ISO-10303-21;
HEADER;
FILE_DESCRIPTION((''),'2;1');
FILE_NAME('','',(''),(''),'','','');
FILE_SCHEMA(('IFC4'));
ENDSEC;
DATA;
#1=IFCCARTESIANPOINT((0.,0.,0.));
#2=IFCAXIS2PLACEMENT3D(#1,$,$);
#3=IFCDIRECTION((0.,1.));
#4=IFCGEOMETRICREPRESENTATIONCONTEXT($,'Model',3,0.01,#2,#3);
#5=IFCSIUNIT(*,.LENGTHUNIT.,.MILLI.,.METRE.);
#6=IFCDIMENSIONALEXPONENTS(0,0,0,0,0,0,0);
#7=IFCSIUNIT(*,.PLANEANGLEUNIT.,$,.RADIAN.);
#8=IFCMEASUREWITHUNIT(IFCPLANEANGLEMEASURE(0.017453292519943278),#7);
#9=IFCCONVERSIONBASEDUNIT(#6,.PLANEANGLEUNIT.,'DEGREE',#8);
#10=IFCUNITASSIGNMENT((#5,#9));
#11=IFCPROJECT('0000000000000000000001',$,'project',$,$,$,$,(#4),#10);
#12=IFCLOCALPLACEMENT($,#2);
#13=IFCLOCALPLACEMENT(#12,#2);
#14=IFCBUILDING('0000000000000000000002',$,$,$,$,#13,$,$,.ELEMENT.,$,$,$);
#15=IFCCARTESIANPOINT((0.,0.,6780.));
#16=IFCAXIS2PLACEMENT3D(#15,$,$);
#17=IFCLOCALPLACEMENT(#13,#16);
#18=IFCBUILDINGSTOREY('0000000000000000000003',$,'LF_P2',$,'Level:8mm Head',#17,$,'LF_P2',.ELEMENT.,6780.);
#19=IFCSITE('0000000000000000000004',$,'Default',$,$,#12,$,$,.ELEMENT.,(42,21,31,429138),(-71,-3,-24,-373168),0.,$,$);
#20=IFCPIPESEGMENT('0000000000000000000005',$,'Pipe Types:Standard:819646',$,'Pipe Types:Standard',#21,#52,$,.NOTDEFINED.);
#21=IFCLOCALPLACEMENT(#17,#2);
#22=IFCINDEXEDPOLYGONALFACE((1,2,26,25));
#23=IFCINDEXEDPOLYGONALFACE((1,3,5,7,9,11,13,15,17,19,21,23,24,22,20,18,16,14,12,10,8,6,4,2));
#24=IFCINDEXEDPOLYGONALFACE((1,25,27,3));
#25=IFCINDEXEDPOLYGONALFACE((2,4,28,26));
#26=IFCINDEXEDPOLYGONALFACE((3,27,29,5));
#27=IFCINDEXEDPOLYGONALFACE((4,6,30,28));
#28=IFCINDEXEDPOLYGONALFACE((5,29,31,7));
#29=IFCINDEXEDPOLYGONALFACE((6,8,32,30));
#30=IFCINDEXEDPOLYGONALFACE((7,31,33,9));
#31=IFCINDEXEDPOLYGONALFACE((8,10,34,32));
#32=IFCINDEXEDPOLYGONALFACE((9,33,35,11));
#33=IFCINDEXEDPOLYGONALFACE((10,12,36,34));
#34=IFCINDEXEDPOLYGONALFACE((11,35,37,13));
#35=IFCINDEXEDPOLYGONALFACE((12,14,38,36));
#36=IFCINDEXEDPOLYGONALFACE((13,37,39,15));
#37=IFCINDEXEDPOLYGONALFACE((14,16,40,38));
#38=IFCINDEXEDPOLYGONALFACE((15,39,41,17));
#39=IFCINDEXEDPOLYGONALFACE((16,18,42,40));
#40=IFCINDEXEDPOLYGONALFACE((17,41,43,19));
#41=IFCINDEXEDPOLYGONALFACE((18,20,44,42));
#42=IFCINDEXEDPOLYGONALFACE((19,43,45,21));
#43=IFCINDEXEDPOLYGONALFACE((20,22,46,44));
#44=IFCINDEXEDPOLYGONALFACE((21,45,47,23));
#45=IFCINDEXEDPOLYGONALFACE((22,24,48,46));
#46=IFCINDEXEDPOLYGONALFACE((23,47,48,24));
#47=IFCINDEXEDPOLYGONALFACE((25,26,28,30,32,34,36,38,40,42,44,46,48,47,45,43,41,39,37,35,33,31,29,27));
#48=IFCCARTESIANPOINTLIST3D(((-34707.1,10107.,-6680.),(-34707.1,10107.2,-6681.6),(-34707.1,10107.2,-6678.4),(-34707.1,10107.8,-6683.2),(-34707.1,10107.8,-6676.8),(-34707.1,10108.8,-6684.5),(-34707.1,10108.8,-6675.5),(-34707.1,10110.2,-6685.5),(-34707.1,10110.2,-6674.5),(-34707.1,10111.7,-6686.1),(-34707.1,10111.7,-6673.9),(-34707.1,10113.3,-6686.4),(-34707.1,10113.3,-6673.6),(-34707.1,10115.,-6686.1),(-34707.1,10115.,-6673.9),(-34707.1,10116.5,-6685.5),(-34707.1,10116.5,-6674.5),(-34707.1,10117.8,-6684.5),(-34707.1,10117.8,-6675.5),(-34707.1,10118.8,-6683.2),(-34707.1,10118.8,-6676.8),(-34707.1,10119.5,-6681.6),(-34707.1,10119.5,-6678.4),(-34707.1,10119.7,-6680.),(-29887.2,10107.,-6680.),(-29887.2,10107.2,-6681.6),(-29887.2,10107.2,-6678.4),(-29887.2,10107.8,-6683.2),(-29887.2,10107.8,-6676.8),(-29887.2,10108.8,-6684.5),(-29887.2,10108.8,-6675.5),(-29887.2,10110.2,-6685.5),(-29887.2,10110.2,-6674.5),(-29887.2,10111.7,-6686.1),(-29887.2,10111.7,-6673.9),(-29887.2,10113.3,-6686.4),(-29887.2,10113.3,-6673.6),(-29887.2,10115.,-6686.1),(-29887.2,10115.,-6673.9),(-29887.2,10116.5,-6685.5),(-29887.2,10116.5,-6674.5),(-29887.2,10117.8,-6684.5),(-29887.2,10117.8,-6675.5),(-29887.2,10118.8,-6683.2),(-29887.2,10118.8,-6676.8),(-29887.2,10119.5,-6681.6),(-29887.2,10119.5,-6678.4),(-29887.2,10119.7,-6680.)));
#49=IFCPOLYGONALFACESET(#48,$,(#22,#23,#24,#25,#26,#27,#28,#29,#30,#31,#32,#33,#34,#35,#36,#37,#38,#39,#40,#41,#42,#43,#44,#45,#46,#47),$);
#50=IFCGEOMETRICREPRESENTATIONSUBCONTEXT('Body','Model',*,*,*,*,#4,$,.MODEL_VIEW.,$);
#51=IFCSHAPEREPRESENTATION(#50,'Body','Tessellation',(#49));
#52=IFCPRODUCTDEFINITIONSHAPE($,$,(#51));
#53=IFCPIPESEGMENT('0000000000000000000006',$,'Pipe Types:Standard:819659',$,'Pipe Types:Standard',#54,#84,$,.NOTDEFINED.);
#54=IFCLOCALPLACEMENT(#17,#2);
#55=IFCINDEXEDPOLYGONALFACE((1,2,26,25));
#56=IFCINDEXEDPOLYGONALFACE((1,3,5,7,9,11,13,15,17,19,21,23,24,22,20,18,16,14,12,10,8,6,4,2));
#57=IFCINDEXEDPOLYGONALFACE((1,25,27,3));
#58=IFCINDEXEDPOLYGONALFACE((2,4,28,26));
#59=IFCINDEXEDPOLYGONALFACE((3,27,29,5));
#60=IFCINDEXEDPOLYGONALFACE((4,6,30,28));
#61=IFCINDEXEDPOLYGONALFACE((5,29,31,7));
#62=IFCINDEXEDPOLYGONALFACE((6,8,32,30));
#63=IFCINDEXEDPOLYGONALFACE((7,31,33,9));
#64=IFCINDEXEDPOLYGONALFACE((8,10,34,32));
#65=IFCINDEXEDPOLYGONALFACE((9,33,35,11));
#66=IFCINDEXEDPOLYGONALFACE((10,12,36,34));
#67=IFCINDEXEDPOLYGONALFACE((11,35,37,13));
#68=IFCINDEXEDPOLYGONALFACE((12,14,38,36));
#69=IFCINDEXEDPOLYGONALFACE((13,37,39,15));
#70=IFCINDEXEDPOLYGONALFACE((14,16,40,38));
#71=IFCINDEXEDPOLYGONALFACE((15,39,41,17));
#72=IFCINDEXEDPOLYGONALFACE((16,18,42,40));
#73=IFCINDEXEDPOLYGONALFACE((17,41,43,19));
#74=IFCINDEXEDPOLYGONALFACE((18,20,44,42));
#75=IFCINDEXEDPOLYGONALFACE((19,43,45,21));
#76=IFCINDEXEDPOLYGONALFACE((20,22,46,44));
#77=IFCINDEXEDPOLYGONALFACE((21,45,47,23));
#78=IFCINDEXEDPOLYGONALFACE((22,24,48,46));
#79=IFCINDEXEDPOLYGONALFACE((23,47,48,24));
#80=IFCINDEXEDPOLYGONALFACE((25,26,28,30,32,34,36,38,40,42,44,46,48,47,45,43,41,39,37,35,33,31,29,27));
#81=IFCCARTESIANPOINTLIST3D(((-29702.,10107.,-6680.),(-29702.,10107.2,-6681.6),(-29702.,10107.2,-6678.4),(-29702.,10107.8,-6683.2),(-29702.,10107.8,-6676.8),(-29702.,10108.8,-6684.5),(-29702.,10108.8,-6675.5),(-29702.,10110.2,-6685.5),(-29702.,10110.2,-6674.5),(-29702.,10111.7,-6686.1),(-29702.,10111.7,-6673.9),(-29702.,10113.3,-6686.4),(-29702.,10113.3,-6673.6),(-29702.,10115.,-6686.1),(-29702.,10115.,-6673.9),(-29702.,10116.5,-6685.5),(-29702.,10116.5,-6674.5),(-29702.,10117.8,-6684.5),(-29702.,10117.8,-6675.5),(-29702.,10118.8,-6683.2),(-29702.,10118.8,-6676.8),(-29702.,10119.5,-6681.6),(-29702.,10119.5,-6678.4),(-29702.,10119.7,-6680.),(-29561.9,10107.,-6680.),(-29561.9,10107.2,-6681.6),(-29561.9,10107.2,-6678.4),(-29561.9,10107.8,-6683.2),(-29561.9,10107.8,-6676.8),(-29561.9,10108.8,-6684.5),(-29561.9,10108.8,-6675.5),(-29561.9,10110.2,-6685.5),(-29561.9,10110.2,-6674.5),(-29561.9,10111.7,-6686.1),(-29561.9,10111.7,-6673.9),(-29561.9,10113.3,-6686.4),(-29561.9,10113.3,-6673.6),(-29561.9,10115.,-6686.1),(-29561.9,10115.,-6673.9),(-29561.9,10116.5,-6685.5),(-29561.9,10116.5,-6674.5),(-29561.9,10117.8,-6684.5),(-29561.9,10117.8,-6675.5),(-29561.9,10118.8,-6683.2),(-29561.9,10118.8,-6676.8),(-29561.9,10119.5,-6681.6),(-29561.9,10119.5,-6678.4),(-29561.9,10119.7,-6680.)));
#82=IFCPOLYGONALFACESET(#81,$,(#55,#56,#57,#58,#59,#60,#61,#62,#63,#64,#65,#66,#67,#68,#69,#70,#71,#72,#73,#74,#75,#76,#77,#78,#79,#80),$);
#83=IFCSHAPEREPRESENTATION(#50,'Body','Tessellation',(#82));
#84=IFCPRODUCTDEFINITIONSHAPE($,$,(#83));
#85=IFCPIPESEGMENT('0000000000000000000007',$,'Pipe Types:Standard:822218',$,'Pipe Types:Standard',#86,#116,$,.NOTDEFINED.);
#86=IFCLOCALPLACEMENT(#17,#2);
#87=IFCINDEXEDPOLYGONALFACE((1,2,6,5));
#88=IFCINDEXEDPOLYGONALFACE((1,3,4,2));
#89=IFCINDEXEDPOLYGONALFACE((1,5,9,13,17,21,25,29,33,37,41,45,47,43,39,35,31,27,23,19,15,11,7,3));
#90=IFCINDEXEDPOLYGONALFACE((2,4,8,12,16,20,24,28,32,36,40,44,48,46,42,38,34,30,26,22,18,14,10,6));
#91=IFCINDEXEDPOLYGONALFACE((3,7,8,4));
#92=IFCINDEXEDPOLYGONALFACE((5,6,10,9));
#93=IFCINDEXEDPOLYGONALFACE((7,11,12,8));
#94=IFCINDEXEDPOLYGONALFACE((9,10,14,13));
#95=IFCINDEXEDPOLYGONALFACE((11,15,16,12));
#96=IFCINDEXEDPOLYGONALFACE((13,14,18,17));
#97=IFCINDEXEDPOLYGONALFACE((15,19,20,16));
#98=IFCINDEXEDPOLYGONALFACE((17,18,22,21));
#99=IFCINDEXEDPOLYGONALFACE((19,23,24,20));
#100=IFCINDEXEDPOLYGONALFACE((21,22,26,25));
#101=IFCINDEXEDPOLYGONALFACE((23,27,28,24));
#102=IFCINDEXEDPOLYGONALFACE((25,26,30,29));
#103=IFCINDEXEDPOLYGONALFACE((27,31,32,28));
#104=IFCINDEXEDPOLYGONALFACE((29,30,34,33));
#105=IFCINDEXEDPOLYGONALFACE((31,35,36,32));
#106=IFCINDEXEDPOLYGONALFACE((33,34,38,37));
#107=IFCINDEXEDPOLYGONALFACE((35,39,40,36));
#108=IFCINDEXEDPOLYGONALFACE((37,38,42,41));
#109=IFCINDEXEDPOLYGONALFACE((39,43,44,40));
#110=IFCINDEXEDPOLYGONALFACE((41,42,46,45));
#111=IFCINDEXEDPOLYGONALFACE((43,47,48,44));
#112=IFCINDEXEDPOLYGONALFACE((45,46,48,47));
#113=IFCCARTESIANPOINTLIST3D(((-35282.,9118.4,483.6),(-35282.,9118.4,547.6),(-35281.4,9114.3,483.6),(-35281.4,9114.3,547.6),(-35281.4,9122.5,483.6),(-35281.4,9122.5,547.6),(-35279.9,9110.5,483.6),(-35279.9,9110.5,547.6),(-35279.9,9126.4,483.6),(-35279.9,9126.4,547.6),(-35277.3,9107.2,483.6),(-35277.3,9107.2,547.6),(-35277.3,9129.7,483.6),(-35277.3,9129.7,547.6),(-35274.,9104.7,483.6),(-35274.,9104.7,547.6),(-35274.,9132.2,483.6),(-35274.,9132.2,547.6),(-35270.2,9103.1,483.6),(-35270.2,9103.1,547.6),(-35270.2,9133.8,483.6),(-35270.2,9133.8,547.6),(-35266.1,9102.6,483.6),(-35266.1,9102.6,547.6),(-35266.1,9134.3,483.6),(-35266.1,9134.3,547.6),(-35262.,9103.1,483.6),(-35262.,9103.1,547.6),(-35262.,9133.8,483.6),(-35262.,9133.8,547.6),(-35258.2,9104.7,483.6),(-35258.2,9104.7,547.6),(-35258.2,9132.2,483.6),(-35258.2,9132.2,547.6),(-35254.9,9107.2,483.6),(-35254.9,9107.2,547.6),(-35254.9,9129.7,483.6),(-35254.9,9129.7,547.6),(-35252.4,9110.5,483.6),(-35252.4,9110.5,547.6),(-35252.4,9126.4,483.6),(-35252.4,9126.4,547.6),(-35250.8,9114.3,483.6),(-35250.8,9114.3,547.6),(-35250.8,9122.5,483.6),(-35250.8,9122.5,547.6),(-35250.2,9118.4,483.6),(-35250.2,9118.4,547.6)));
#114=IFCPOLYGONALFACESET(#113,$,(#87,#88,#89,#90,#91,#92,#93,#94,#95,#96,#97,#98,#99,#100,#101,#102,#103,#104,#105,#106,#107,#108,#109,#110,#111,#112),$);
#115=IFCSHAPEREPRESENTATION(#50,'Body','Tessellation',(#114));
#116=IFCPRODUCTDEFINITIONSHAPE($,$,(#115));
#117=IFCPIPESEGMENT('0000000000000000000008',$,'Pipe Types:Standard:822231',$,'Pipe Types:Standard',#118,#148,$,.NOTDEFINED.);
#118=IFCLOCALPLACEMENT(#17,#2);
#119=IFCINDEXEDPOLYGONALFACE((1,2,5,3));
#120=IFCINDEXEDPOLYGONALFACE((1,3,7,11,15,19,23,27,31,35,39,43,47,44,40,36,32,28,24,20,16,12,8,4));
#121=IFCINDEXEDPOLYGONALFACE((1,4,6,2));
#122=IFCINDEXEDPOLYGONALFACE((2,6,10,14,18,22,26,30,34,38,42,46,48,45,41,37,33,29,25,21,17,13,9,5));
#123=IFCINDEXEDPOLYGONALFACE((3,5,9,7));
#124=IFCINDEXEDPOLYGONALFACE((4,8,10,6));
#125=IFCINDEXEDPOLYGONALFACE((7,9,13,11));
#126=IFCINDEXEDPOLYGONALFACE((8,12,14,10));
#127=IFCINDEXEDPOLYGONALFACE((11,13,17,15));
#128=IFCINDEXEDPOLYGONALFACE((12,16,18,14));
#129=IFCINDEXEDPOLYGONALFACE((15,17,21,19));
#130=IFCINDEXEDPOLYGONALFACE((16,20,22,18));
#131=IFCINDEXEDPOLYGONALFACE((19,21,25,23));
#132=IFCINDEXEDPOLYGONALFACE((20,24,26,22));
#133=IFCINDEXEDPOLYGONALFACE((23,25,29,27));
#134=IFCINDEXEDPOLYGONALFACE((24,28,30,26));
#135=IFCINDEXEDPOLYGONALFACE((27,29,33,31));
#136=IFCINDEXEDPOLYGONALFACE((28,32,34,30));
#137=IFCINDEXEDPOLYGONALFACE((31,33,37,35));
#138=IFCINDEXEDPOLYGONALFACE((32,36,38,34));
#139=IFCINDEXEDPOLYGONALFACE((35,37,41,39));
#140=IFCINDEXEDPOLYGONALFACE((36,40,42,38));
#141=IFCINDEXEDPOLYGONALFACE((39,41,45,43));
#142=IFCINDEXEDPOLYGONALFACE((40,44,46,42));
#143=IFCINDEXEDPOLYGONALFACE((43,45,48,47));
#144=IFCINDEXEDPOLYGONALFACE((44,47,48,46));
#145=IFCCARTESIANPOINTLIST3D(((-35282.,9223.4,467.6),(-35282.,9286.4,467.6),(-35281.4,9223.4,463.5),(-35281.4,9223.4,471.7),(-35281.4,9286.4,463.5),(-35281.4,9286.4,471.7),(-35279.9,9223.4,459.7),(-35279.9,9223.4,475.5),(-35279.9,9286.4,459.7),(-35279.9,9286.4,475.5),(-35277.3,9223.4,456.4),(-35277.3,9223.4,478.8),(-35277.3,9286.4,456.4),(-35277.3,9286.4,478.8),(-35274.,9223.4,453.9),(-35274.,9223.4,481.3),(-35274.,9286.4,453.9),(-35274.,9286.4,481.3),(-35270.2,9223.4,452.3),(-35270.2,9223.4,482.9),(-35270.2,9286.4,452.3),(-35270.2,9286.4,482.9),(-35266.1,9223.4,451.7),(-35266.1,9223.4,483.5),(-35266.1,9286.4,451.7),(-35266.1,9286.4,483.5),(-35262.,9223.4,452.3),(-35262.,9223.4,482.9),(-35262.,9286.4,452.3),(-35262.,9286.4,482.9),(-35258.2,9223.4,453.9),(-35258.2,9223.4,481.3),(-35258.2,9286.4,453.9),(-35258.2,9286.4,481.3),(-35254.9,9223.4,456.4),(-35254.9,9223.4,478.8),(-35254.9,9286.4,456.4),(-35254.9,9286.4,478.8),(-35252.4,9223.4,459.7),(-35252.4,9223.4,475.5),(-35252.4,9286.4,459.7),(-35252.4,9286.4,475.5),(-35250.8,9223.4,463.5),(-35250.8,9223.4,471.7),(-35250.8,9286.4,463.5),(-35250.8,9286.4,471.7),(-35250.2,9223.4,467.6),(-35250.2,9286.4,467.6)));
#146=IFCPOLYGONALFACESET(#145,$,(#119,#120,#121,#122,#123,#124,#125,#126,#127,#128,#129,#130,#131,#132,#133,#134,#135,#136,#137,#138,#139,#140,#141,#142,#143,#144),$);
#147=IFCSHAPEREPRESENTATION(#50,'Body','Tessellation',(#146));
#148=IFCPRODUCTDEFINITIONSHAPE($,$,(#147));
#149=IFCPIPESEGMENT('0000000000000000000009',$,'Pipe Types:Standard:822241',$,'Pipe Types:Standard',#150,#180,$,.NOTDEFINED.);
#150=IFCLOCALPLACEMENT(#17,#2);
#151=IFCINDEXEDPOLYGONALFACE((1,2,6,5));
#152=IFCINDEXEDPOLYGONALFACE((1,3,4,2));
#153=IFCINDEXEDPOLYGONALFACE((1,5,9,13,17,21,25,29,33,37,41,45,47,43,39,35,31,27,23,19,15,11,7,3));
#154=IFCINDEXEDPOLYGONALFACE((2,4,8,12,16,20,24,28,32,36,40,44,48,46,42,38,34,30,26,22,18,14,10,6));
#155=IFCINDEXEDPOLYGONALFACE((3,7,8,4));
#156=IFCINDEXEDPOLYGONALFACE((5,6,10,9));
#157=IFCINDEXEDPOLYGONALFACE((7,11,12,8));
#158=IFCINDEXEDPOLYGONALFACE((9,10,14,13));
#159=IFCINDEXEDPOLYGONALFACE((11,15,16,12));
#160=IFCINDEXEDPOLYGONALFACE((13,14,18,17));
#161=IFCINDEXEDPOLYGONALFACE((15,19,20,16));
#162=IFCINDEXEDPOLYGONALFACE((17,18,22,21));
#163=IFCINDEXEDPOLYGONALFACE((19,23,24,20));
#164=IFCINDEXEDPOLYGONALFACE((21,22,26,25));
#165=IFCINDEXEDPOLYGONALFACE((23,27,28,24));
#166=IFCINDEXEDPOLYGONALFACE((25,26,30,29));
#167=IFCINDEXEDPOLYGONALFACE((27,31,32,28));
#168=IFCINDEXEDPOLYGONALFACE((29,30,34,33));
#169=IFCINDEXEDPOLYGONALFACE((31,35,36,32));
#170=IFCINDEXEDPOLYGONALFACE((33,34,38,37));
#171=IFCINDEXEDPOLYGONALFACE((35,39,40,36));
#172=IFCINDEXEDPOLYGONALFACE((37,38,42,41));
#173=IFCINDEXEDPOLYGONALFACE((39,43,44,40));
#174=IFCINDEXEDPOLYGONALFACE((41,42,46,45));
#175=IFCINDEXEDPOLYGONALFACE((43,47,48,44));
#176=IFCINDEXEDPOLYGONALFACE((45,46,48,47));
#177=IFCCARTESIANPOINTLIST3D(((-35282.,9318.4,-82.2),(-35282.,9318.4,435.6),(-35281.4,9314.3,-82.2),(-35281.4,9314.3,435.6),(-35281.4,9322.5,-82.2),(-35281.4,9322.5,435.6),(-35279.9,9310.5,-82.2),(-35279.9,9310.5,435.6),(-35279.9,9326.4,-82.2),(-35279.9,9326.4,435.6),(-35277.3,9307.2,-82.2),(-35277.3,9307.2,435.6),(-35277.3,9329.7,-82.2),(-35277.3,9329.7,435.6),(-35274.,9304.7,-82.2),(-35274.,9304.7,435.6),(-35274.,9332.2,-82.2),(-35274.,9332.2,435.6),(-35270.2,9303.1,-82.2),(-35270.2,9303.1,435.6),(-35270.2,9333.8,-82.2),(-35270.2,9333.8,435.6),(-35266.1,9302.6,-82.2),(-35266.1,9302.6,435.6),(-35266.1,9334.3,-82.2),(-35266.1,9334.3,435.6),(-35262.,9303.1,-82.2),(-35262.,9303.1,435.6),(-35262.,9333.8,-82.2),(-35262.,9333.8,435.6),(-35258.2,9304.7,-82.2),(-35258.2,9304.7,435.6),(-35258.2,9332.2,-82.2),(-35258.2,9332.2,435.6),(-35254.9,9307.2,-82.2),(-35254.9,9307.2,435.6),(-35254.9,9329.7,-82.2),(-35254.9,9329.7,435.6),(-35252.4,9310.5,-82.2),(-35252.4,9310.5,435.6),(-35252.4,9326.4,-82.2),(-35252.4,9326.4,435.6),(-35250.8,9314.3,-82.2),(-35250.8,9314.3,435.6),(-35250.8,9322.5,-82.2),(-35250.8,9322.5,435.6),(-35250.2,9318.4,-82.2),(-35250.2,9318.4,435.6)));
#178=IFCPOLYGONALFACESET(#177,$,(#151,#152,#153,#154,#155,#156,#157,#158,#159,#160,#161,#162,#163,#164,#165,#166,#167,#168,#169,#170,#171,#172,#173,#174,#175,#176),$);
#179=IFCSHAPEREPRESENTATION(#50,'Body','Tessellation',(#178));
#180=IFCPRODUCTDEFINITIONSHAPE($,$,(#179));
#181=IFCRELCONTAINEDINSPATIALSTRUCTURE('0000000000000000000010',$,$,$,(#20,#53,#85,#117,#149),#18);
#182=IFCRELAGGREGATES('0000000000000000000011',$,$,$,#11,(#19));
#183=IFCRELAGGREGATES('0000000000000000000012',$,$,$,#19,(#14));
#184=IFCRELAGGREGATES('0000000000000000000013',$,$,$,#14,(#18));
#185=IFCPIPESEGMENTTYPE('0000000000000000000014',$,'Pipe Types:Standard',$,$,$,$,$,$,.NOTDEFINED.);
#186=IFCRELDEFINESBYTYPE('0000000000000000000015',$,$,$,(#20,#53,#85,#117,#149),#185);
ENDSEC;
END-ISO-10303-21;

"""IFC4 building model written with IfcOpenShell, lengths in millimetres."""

from ifc_helpers import new_model, entity, si_unit, converted_unit, direction, frame, origin, place, context, subcontext, project, spatial, arc, indexed_curve, outline, extrude, type_object, element, save


model = new_model("IFC4")

# Units and contexts
model_context = context("Model", 3, precision=0.01, world=origin(), true_north=direction((0.0, 1.0)))
body_context = subcontext(model_context, "Body", "Model", "MODEL_VIEW")
ifc_project = project(units=[si_unit("LENGTHUNIT", "METRE", prefix="MILLI"), converted_unit("PLANEANGLEUNIT", "DEGREE", entity("IfcPlaneAngleMeasure", 0.017453292519943278), si_unit("PLANEANGLEUNIT", "RADIAN"), dimensions=[0, 0, 0, 0, 0, 0, 0])], contexts=[model_context])

# Site, building, storey
site_placement = place(None, origin())
site = spatial("IfcSite", under=ifc_project, at=site_placement, Name="Default", CompositionType="ELEMENT", RefLatitude=(42, 21, 31, 429138), RefLongitude=(-71, -3, -24, -373168), RefElevation=0.0)
building_placement = place(site_placement, origin())
building = spatial("IfcBuilding", under=site, at=building_placement, CompositionType="ELEMENT")
storey_placement = place(building_placement, frame((0.0, 0.0, 6780.0)))
storey = spatial("IfcBuildingStorey", under=building, at=storey_placement, Name="LF_P2", ObjectType="Level:8mm Head", LongName="LF_P2", CompositionType="ELEMENT", Elevation=6780.0)

# Pipe segments
pipe_segment_type_1 = type_object("IfcPipeSegmentType", Name="Pipe Types:Standard", PredefinedType="NOTDEFINED")
pipe_segment_1_placement = place(storey_placement, origin())
element("IfcPipeSegment", 1, at=pipe_segment_1_placement, inside=storey, type_object=pipe_segment_type_1, Name="Pipe Types:Standard:819646", ObjectType="Pipe Types:Standard", PredefinedType="NOTDEFINED", context=body_context, shape_type="SweptSolid", body=[
    extrude(outline(indexed_curve([(6.4, 0.0), (4.5, 4.5), (0.0, 6.3), (-4.5, 4.5), (-6.3, 0.0), (-4.5, -4.5), (0.0, -6.3), (4.5, -4.5)], segments=[arc(1, 2, 3), arc(3, 4, 5), arc(5, 6, 7), arc(7, 8, 1)], self_intersect=False)), frame((-34707.1, 10113.3, -6680.0), z_axis=(1.0, 0.0, 0.0), x_axis=(0.0, 1.0, 0.0)), (0.0, 0.0, 1.0), 4819.9),
])
pipe_segment_2_placement = place(storey_placement, origin())
element("IfcPipeSegment", 2, at=pipe_segment_2_placement, inside=storey, type_object=pipe_segment_type_1, Name="Pipe Types:Standard:819659", ObjectType="Pipe Types:Standard", PredefinedType="NOTDEFINED", context=body_context, shape_type="SweptSolid", body=[
    extrude(outline(indexed_curve([(6.4, 0.0), (4.5, 4.5), (0.0, 6.3), (-4.5, 4.5), (-6.3, 0.0), (-4.5, -4.5), (0.0, -6.3), (4.5, -4.5)], segments=[arc(1, 2, 3), arc(3, 4, 5), arc(5, 6, 7), arc(7, 8, 1)], self_intersect=False)), frame((-29702.0, 10113.3, -6680.0), z_axis=(1.0, 0.0, 0.0), x_axis=(0.0, 1.0, 0.0)), (0.0, 0.0, 1.0), 140.1),
])
pipe_segment_3_placement = place(storey_placement, origin())
element("IfcPipeSegment", 3, at=pipe_segment_3_placement, inside=storey, type_object=pipe_segment_type_1, Name="Pipe Types:Standard:822218", ObjectType="Pipe Types:Standard", PredefinedType="NOTDEFINED", context=body_context, shape_type="SweptSolid", body=[
    extrude(outline(indexed_curve([(15.9, 0.0), (11.2, 11.2), (0.0, 15.9), (-11.2, 11.2), (-15.9, 0.0), (-11.2, -11.2), (0.0, -15.9), (11.2, -11.2)], segments=[arc(1, 2, 3), arc(3, 4, 5), arc(5, 6, 7), arc(7, 8, 1)], self_intersect=False)), frame((-35266.1, 9118.4, 483.6)), (0.0, 0.0, 1.0), 64.0),
])
pipe_segment_4_placement = place(storey_placement, origin())
element("IfcPipeSegment", 4, at=pipe_segment_4_placement, inside=storey, type_object=pipe_segment_type_1, Name="Pipe Types:Standard:822231", ObjectType="Pipe Types:Standard", PredefinedType="NOTDEFINED", context=body_context, shape_type="SweptSolid", body=[
    extrude(outline(indexed_curve([(15.9, 0.0), (11.2, 11.2), (0.0, 15.9), (-11.2, 11.2), (-15.9, 0.0), (-11.2, -11.2), (0.0, -15.9), (11.2, -11.2)], segments=[arc(1, 2, 3), arc(3, 4, 5), arc(5, 6, 7), arc(7, 8, 1)], self_intersect=False)), frame((-35266.1, 9223.4, 467.6), z_axis=(0.0, 1.0, 0.0), x_axis=(-1.0, 0.0, 0.0)), (0.0, 0.0, 1.0), 63.0),
])
pipe_segment_5_placement = place(storey_placement, origin())
element("IfcPipeSegment", 5, at=pipe_segment_5_placement, inside=storey, type_object=pipe_segment_type_1, Name="Pipe Types:Standard:822241", ObjectType="Pipe Types:Standard", PredefinedType="NOTDEFINED", context=body_context, shape_type="SweptSolid", body=[
    extrude(outline(indexed_curve([(15.9, 0.0), (11.2, 11.2), (0.0, 15.9), (-11.2, 11.2), (-15.9, 0.0), (-11.2, -11.2), (0.0, -15.9), (11.2, -11.2)], segments=[arc(1, 2, 3), arc(3, 4, 5), arc(5, 6, 7), arc(7, 8, 1)], self_intersect=False)), frame((-35266.1, 9318.4, -82.2), z_axis=(0.0, 0.0, 1.0), x_axis=(-1.0, 0.0, 0.0)), (0.0, 0.0, 1.0), 517.8),
])

save(model, "model.ifc")
